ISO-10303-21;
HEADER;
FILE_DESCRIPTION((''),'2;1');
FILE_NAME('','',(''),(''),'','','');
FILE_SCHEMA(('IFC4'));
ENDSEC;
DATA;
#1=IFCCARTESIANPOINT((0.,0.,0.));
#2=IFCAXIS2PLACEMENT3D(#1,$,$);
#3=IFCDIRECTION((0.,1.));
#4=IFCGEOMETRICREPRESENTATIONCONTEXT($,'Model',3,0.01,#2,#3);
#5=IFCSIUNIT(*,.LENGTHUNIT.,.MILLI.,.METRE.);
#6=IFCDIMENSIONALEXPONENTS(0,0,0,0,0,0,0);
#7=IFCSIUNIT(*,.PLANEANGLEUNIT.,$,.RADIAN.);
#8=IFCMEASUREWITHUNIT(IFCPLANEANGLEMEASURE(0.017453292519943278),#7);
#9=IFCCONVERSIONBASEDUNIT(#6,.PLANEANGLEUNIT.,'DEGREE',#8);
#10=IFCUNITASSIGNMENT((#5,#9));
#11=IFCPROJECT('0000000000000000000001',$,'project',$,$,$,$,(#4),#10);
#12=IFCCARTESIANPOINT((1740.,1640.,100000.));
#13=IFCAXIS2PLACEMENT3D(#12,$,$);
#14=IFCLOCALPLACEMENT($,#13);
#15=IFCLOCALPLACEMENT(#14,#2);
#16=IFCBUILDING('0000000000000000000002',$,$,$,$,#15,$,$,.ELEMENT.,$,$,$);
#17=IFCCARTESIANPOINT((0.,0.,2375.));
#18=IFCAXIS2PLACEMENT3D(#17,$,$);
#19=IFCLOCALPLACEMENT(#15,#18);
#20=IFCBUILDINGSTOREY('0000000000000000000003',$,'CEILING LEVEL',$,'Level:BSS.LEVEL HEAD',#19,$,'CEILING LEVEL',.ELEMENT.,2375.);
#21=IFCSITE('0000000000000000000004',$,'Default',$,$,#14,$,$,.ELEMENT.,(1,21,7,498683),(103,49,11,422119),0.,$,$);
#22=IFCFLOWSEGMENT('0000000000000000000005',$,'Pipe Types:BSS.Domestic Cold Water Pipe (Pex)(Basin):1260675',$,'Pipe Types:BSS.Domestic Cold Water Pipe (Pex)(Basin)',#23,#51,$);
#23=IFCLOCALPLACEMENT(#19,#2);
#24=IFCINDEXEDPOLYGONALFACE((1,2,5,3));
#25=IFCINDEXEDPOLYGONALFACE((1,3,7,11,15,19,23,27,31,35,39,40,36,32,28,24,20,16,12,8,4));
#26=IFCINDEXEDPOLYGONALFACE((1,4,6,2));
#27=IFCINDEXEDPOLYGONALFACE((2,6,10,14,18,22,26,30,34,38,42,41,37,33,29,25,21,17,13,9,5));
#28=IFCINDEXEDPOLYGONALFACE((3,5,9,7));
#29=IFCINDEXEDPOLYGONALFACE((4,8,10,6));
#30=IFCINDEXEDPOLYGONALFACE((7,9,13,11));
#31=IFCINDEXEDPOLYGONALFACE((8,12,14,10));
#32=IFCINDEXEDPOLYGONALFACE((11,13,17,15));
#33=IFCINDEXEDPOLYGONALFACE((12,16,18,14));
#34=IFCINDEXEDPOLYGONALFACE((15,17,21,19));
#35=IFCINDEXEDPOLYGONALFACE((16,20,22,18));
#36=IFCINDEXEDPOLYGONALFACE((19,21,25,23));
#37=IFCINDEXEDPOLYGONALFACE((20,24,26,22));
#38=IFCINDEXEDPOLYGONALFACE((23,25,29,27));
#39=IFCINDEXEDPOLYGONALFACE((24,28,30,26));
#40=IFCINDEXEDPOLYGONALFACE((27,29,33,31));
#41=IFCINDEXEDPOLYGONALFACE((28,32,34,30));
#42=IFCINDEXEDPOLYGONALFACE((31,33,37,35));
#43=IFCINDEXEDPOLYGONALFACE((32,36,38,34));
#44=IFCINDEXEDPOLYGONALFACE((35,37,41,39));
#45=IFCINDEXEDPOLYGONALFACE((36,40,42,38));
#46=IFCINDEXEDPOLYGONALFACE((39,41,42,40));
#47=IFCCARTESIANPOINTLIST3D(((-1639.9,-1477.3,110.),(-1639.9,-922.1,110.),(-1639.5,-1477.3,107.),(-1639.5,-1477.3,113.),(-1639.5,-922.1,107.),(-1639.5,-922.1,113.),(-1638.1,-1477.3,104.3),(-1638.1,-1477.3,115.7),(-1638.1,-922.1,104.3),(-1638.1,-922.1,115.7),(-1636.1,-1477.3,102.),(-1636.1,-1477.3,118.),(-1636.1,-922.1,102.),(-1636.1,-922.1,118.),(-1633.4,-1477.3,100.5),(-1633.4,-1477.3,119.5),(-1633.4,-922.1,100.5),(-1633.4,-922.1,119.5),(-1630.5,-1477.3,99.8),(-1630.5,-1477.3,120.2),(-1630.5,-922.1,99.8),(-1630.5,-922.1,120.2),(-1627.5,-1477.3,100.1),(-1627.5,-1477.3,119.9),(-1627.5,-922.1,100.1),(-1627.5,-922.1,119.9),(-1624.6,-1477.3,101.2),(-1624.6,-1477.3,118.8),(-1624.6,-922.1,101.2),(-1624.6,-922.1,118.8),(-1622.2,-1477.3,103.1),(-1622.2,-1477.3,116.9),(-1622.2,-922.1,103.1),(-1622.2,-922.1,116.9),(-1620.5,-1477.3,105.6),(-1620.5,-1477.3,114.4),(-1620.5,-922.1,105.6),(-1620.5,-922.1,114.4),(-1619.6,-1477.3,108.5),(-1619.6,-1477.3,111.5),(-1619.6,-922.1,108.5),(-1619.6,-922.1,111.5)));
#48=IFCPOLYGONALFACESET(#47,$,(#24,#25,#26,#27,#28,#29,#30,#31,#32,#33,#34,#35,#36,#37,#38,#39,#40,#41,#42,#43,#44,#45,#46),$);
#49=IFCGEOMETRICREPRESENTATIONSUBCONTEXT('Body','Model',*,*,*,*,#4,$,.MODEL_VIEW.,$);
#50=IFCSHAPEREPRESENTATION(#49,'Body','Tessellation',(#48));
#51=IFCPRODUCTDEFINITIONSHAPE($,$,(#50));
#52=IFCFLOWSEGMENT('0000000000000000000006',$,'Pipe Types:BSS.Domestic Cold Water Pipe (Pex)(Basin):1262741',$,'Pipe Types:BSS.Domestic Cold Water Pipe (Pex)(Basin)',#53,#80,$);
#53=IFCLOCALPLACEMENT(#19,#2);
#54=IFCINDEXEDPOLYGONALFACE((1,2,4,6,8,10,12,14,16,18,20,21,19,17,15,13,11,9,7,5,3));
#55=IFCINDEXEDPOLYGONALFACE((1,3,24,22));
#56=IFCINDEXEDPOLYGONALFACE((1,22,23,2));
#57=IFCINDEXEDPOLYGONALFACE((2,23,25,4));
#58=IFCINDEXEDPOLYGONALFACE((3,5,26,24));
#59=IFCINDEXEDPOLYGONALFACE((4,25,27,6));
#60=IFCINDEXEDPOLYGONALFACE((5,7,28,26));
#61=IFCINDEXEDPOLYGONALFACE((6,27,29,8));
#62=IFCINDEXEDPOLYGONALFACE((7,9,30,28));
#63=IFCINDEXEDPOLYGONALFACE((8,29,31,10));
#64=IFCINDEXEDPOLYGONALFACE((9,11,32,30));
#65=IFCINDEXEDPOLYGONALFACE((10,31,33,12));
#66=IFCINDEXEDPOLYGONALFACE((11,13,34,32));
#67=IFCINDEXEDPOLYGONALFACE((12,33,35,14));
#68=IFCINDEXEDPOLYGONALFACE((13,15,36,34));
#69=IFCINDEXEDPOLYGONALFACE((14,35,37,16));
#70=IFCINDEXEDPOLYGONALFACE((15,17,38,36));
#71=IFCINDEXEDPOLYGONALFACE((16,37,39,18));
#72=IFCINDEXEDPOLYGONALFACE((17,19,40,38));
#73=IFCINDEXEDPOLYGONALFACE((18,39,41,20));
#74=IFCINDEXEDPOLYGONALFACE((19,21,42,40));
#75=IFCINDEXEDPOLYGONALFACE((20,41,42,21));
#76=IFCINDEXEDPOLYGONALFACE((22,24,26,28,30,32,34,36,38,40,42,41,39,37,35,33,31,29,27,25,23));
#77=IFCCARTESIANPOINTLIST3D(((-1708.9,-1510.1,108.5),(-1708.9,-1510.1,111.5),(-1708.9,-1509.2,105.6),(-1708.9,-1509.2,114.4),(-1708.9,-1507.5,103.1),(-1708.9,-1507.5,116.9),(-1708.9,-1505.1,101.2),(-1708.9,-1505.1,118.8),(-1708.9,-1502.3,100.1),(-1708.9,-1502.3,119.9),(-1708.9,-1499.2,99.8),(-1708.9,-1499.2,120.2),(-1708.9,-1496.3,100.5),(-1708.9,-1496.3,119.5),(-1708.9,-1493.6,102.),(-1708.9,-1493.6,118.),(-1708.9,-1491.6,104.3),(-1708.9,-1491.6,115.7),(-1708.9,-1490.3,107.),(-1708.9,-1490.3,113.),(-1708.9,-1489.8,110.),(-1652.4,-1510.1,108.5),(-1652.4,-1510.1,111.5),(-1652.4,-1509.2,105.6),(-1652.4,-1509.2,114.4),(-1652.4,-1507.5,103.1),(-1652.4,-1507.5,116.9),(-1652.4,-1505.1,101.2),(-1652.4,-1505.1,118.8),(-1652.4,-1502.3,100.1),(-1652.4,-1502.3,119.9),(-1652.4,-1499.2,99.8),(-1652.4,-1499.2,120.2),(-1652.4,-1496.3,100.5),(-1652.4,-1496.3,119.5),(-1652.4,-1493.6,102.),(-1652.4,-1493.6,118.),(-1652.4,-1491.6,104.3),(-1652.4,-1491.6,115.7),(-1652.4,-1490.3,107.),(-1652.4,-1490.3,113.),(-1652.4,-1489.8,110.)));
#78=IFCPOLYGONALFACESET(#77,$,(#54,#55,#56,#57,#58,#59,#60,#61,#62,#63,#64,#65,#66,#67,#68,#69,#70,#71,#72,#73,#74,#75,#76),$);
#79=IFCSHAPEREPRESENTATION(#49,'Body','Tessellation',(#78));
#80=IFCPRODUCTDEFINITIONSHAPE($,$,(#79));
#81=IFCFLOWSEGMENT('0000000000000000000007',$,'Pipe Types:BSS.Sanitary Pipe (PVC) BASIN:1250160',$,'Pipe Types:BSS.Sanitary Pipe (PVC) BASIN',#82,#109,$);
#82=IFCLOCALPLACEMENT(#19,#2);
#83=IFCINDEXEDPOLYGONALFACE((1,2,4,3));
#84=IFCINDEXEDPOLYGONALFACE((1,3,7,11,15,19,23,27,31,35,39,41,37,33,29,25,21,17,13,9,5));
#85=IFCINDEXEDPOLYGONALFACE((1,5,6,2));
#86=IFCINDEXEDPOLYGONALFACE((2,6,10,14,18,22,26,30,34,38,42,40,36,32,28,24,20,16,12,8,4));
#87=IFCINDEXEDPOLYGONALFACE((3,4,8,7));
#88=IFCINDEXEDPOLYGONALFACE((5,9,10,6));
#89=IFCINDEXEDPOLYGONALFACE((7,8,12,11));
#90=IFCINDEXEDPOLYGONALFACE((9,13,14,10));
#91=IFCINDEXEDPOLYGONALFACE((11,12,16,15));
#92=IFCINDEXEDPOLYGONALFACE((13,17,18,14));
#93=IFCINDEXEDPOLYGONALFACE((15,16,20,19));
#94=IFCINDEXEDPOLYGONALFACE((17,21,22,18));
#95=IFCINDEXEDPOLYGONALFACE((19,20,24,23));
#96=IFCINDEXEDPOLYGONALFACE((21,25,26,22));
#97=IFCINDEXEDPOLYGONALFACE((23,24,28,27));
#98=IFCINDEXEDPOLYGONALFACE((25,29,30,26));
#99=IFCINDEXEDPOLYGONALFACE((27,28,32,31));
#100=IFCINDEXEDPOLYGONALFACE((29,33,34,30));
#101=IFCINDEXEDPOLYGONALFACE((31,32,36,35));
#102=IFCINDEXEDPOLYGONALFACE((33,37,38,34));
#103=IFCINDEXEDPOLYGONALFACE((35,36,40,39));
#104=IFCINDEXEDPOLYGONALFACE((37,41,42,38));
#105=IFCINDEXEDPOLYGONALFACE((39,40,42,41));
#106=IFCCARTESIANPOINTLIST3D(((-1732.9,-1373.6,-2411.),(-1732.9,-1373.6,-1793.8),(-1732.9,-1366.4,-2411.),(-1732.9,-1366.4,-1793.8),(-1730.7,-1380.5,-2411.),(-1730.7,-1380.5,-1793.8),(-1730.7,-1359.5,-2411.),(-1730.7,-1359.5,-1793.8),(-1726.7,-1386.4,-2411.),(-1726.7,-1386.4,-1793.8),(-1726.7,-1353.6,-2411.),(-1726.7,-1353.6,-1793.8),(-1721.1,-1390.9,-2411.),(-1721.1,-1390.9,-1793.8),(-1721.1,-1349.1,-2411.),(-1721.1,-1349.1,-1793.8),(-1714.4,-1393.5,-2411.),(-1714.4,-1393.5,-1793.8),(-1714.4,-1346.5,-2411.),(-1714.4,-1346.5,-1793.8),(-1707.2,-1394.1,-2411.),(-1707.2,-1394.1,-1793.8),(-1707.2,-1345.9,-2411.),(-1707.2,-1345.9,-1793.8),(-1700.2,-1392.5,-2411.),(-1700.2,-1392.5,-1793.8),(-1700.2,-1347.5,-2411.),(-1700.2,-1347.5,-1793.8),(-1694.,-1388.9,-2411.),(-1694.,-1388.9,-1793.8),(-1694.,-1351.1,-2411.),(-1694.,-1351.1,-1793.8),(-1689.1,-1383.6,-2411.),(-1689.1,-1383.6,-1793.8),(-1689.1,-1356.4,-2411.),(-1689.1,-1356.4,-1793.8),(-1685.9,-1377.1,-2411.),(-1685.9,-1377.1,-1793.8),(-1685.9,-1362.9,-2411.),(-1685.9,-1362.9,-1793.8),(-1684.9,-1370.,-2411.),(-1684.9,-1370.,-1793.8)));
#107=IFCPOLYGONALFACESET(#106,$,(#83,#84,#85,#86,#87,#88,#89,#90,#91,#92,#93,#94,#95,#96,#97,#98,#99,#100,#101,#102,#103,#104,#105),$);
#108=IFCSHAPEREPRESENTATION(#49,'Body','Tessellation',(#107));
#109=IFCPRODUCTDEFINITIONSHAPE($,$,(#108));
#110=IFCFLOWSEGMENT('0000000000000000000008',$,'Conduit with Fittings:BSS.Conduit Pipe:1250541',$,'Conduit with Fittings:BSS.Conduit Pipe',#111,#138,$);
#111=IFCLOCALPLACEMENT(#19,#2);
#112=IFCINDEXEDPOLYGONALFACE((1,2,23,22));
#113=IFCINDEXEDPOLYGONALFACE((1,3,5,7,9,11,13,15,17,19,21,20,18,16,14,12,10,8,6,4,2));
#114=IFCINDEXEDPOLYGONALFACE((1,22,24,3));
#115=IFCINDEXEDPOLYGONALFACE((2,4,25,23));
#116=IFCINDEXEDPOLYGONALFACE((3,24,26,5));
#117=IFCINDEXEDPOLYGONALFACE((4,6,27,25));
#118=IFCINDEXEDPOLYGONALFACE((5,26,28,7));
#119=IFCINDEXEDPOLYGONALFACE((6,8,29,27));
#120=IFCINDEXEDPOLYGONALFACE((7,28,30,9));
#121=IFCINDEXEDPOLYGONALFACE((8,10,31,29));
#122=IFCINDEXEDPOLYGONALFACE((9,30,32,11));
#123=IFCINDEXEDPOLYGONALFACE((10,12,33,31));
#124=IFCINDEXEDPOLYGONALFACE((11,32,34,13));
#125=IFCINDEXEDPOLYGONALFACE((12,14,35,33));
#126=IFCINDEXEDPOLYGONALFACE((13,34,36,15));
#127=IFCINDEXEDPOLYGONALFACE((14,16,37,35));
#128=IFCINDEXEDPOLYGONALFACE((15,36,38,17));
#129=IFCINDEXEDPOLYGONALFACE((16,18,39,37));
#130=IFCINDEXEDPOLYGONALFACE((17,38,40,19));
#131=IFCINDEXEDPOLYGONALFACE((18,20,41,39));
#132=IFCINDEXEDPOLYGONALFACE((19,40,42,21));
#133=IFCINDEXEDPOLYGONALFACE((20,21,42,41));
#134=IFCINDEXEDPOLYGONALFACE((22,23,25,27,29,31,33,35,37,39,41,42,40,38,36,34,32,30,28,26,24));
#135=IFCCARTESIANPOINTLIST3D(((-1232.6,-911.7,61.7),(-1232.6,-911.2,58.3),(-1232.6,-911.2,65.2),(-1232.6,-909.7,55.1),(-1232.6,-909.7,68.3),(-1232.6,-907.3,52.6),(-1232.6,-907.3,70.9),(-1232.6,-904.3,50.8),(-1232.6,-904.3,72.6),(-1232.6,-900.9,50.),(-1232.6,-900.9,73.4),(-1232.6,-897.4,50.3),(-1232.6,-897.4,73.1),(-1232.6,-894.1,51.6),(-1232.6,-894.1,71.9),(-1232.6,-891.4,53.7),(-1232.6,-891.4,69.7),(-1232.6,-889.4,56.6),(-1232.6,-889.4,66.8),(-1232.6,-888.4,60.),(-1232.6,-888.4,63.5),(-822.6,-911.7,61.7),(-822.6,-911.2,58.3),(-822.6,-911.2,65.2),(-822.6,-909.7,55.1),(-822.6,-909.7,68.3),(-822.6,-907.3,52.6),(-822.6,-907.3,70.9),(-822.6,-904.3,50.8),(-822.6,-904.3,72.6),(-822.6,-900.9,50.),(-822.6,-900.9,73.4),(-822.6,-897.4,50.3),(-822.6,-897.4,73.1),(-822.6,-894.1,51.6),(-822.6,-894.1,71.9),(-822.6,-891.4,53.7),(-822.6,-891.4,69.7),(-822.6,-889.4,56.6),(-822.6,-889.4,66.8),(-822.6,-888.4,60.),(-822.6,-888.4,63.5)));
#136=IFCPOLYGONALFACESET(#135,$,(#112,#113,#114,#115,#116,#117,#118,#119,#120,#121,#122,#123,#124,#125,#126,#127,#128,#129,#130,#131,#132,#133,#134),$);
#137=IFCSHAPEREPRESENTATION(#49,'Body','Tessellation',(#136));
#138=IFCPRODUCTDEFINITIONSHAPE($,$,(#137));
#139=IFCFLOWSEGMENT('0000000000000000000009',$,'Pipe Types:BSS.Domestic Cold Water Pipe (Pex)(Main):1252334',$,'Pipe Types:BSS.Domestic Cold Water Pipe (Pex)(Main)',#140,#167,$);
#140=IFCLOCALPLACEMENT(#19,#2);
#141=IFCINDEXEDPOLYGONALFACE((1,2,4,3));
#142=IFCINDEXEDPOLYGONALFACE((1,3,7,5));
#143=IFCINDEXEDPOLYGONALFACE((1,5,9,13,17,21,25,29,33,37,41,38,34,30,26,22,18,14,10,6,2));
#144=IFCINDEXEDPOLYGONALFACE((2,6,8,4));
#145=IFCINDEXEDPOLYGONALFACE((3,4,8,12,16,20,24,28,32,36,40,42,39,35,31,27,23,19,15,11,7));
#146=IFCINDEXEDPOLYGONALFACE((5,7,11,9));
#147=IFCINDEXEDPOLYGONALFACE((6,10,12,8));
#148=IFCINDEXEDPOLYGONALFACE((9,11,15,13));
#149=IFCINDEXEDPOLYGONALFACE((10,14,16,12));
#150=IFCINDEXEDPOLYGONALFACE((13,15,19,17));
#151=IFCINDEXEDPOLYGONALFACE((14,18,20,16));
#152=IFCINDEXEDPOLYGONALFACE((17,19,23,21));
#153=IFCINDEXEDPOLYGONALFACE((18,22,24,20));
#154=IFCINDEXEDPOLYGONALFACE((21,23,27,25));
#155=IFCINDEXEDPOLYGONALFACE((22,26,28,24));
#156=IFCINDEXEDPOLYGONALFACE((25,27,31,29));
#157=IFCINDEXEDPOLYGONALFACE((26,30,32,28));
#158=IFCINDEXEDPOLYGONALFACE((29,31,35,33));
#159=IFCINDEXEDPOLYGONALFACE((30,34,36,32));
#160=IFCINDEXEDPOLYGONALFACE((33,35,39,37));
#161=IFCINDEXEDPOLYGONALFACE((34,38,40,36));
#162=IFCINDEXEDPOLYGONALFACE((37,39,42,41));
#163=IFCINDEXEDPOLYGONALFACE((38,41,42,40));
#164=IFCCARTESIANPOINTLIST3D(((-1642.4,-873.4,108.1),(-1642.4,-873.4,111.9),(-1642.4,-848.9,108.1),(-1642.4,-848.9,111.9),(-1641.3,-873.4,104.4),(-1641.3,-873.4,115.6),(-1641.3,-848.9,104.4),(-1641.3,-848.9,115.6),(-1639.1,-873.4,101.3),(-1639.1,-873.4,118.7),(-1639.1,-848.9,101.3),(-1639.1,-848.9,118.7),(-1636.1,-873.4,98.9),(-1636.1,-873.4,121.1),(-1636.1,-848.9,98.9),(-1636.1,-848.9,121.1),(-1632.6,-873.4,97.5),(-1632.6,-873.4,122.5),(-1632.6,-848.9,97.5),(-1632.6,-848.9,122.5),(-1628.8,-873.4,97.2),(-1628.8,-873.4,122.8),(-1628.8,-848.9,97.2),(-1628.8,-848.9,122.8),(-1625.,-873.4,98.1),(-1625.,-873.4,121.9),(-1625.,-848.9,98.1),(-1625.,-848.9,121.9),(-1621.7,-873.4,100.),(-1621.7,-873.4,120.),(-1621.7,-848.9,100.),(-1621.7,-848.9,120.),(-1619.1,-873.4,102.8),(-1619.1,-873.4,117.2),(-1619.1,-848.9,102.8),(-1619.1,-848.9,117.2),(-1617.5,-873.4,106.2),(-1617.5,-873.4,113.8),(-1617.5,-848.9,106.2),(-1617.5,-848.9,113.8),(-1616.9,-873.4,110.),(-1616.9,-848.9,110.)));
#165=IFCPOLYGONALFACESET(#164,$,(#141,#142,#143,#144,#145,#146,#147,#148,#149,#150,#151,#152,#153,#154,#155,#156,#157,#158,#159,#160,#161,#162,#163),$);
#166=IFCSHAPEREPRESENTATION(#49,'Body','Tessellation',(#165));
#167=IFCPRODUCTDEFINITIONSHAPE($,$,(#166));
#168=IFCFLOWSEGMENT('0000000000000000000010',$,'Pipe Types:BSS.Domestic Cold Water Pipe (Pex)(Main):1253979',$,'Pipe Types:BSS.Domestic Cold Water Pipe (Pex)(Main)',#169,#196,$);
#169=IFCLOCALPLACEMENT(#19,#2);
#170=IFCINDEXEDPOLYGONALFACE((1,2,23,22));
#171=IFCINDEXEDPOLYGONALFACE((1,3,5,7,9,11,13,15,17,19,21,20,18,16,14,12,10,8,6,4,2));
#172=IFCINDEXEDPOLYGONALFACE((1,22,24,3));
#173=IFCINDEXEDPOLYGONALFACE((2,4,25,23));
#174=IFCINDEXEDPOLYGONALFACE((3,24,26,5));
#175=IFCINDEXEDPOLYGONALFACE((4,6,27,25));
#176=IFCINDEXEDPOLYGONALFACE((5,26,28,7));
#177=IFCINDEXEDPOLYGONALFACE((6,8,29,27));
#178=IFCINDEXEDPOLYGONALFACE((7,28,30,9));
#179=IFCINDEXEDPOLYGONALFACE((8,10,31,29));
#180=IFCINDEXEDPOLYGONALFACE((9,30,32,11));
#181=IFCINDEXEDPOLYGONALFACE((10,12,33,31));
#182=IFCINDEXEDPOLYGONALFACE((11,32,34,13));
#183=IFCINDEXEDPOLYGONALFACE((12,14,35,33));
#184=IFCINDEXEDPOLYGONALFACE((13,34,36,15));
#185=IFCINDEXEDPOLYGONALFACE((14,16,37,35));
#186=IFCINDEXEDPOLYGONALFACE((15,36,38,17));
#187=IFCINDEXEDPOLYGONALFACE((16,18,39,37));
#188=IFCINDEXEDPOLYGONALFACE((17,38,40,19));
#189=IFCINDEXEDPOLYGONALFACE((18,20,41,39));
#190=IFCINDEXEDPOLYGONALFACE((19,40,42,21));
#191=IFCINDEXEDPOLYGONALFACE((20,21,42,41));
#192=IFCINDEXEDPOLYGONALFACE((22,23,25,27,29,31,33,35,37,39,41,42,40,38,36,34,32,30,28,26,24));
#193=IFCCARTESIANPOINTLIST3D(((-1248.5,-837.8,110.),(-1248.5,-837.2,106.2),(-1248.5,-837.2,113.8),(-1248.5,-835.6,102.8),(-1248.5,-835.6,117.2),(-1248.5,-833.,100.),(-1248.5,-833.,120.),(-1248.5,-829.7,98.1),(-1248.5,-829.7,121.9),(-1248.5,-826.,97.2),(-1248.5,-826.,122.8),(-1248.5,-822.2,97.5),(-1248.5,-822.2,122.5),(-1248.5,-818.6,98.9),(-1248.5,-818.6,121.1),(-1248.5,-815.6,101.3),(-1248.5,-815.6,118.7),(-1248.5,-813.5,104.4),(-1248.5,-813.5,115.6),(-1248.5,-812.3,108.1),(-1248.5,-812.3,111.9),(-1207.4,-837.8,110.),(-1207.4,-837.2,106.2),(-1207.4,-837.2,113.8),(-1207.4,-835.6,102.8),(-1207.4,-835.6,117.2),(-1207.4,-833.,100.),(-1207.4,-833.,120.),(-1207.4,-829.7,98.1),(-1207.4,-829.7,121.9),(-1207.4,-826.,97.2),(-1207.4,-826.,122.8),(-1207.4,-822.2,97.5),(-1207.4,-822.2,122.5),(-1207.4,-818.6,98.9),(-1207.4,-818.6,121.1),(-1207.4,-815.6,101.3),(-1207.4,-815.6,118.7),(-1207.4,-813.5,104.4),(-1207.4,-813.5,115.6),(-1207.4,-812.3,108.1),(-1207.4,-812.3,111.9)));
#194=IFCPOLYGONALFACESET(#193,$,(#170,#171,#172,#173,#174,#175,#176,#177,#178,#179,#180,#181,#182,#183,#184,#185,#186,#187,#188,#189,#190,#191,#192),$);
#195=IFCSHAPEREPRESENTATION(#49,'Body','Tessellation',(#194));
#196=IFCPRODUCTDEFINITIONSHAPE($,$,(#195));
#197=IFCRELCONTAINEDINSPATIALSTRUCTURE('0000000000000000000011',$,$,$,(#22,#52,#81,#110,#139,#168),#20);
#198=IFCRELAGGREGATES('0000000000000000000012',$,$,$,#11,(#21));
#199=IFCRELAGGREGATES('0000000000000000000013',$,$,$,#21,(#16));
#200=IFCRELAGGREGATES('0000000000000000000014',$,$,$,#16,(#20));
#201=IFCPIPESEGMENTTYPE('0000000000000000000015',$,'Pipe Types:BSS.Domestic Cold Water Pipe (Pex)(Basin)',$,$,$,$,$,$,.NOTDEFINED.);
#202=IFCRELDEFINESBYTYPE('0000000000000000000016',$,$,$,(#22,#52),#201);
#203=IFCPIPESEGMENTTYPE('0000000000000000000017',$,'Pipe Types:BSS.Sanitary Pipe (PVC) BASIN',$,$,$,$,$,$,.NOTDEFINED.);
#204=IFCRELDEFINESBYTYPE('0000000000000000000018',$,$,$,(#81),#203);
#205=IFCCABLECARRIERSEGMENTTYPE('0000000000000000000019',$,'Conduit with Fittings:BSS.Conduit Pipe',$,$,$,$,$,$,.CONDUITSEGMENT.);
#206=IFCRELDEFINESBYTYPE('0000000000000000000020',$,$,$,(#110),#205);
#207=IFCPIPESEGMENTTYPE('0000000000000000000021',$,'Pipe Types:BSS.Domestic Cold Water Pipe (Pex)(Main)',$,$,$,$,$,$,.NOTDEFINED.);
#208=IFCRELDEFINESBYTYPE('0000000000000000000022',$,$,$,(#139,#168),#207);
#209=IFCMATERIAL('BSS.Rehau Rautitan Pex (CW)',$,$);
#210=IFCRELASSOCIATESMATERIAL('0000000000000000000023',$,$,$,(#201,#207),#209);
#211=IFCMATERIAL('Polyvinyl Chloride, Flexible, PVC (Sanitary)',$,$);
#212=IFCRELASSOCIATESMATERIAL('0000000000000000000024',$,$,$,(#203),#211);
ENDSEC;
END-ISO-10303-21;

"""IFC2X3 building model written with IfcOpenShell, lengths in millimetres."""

from ifc_helpers import new_model, entity, si_unit, converted_unit, direction, frame, frame_2d, origin, origin_2d_with_axis, place, context, subcontext, project, spatial, circle, extrude, material, type_object, element, save


model = new_model("IFC2X3")

# Units and contexts
model_context = context("Model", 3, precision=0.01, world=origin(), true_north=direction((0.0, 1.0)))
body_context = subcontext(model_context, "Body", "Model", "MODEL_VIEW")
ifc_project = project(units=[si_unit("LENGTHUNIT", "METRE", prefix="MILLI"), converted_unit("PLANEANGLEUNIT", "DEGREE", entity("IfcPlaneAngleMeasure", 0.017453292519943278), si_unit("PLANEANGLEUNIT", "RADIAN"), dimensions=[0, 0, 0, 0, 0, 0, 0])], contexts=[model_context])

# Site, building, storey
site_placement = place(None, frame((1740.0, 1640.0, 100000.0)))
site = spatial("IfcSite", under=ifc_project, at=site_placement, Name="Default", CompositionType="ELEMENT", RefLatitude=(1, 21, 7, 498683), RefLongitude=(103, 49, 11, 422119), RefElevation=0.0)
building_placement = place(site_placement, origin())
building = spatial("IfcBuilding", under=site, at=building_placement, CompositionType="ELEMENT")
storey_placement = place(building_placement, frame((0.0, 0.0, 2375.0)))
storey = spatial("IfcBuildingStorey", under=building, at=storey_placement, Name="CEILING LEVEL", ObjectType="Level:BSS.LEVEL HEAD", LongName="CEILING LEVEL", CompositionType="ELEMENT", Elevation=2375.0)

# Flow segments
ifc_material_1 = material(Name="BSS.Rehau Rautitan Pex (CW)")
pipe_segment_type_1 = type_object("IfcPipeSegmentType", Name="Pipe Types:BSS.Domestic Cold Water Pipe (Pex)(Basin)", PredefinedType="NOTDEFINED", material=ifc_material_1)
flow_segment_1_placement = place(storey_placement, origin())
element("IfcFlowSegment", 1, at=flow_segment_1_placement, inside=storey, type_object=pipe_segment_type_1, Name="Pipe Types:BSS.Domestic Cold Water Pipe (Pex)(Basin):1260675", ObjectType="Pipe Types:BSS.Domestic Cold Water Pipe (Pex)(Basin)", context=body_context, shape_type="SweptSolid", body=[
    extrude(circle(Radius=10.2, at=frame_2d((0.0, 0.0), x_axis=(1.0, 0.0))), frame((-1629.7, -1477.3, 110.0), z_axis=(0.0, 1.0, 0.0), x_axis=(-1.0, 0.0, 0.0)), (0.0, 0.0, 1.0), 555.2),
])
flow_segment_2_placement = place(storey_placement, origin())
element("IfcFlowSegment", 2, at=flow_segment_2_placement, inside=storey, type_object=pipe_segment_type_1, Name="Pipe Types:BSS.Domestic Cold Water Pipe (Pex)(Basin):1262741", ObjectType="Pipe Types:BSS.Domestic Cold Water Pipe (Pex)(Basin)", context=body_context, shape_type="SweptSolid", body=[
    extrude(circle(Radius=10.2, at=origin_2d_with_axis()), frame((-1708.9, -1500.0, 110.0), z_axis=(1.0, 0.0, 0.0), x_axis=(0.0, 1.0, 0.0)), (0.0, 0.0, 1.0), 56.5),
])
ifc_material_2 = material(Name="Polyvinyl Chloride, Flexible, PVC (Sanitary)")
pipe_segment_type_2 = type_object("IfcPipeSegmentType", Name="Pipe Types:BSS.Sanitary Pipe (PVC) BASIN", PredefinedType="NOTDEFINED", material=ifc_material_2)
flow_segment_3_placement = place(storey_placement, origin())
element("IfcFlowSegment", 3, at=flow_segment_3_placement, inside=storey, type_object=pipe_segment_type_2, Name="Pipe Types:BSS.Sanitary Pipe (PVC) BASIN:1250160", ObjectType="Pipe Types:BSS.Sanitary Pipe (PVC) BASIN", context=body_context, shape_type="SweptSolid", body=[
    extrude(circle(Radius=24.1, at=origin_2d_with_axis()), frame((-1709.0, -1370.0, -2411.0)), (0.0, 0.0, 1.0), 617.2),
])
cable_carrier_segment_type = type_object("IfcCableCarrierSegmentType", Name="Conduit with Fittings:BSS.Conduit Pipe", PredefinedType="CONDUITSEGMENT")
flow_segment_4_placement = place(storey_placement, origin())
element("IfcFlowSegment", 4, at=flow_segment_4_placement, inside=storey, type_object=cable_carrier_segment_type, Name="Conduit with Fittings:BSS.Conduit Pipe:1250541", ObjectType="Conduit with Fittings:BSS.Conduit Pipe", context=body_context, shape_type="SweptSolid", body=[
    extrude(circle(Radius=11.7, at=frame_2d((0.0, 0.0), x_axis=(1.0, 0.0))), frame((-1232.6, -900.0, 61.7), z_axis=(1.0, 0.0, 0.0), x_axis=(0.0, -1.0, 0.0)), (0.0, 0.0, 1.0), 410.0),
])
pipe_segment_type_3 = type_object("IfcPipeSegmentType", Name="Pipe Types:BSS.Domestic Cold Water Pipe (Pex)(Main)", PredefinedType="NOTDEFINED", material=ifc_material_1)
flow_segment_5_placement = place(storey_placement, origin())
element("IfcFlowSegment", 5, at=flow_segment_5_placement, inside=storey, type_object=pipe_segment_type_3, Name="Pipe Types:BSS.Domestic Cold Water Pipe (Pex)(Main):1252334", ObjectType="Pipe Types:BSS.Domestic Cold Water Pipe (Pex)(Main)", context=body_context, shape_type="SweptSolid", body=[
    extrude(circle(Radius=12.8, at=origin_2d_with_axis()), frame((-1629.7, -873.4, 110.0), z_axis=(0.0, 1.0, 0.0), x_axis=(1.0, 0.0, 0.0)), (0.0, 0.0, 1.0), 24.5),
])
flow_segment_6_placement = place(storey_placement, origin())
element("IfcFlowSegment", 6, at=flow_segment_6_placement, inside=storey, type_object=pipe_segment_type_3, Name="Pipe Types:BSS.Domestic Cold Water Pipe (Pex)(Main):1253979", ObjectType="Pipe Types:BSS.Domestic Cold Water Pipe (Pex)(Main)", context=body_context, shape_type="SweptSolid", body=[
    extrude(circle(Radius=12.8, at=origin_2d_with_axis()), frame((-1248.5, -825.0, 110.0), z_axis=(1.0, 0.0, 0.0), x_axis=(0.0, -1.0, 0.0)), (0.0, 0.0, 1.0), 41.1),
])

save(model, "model.ifc")
